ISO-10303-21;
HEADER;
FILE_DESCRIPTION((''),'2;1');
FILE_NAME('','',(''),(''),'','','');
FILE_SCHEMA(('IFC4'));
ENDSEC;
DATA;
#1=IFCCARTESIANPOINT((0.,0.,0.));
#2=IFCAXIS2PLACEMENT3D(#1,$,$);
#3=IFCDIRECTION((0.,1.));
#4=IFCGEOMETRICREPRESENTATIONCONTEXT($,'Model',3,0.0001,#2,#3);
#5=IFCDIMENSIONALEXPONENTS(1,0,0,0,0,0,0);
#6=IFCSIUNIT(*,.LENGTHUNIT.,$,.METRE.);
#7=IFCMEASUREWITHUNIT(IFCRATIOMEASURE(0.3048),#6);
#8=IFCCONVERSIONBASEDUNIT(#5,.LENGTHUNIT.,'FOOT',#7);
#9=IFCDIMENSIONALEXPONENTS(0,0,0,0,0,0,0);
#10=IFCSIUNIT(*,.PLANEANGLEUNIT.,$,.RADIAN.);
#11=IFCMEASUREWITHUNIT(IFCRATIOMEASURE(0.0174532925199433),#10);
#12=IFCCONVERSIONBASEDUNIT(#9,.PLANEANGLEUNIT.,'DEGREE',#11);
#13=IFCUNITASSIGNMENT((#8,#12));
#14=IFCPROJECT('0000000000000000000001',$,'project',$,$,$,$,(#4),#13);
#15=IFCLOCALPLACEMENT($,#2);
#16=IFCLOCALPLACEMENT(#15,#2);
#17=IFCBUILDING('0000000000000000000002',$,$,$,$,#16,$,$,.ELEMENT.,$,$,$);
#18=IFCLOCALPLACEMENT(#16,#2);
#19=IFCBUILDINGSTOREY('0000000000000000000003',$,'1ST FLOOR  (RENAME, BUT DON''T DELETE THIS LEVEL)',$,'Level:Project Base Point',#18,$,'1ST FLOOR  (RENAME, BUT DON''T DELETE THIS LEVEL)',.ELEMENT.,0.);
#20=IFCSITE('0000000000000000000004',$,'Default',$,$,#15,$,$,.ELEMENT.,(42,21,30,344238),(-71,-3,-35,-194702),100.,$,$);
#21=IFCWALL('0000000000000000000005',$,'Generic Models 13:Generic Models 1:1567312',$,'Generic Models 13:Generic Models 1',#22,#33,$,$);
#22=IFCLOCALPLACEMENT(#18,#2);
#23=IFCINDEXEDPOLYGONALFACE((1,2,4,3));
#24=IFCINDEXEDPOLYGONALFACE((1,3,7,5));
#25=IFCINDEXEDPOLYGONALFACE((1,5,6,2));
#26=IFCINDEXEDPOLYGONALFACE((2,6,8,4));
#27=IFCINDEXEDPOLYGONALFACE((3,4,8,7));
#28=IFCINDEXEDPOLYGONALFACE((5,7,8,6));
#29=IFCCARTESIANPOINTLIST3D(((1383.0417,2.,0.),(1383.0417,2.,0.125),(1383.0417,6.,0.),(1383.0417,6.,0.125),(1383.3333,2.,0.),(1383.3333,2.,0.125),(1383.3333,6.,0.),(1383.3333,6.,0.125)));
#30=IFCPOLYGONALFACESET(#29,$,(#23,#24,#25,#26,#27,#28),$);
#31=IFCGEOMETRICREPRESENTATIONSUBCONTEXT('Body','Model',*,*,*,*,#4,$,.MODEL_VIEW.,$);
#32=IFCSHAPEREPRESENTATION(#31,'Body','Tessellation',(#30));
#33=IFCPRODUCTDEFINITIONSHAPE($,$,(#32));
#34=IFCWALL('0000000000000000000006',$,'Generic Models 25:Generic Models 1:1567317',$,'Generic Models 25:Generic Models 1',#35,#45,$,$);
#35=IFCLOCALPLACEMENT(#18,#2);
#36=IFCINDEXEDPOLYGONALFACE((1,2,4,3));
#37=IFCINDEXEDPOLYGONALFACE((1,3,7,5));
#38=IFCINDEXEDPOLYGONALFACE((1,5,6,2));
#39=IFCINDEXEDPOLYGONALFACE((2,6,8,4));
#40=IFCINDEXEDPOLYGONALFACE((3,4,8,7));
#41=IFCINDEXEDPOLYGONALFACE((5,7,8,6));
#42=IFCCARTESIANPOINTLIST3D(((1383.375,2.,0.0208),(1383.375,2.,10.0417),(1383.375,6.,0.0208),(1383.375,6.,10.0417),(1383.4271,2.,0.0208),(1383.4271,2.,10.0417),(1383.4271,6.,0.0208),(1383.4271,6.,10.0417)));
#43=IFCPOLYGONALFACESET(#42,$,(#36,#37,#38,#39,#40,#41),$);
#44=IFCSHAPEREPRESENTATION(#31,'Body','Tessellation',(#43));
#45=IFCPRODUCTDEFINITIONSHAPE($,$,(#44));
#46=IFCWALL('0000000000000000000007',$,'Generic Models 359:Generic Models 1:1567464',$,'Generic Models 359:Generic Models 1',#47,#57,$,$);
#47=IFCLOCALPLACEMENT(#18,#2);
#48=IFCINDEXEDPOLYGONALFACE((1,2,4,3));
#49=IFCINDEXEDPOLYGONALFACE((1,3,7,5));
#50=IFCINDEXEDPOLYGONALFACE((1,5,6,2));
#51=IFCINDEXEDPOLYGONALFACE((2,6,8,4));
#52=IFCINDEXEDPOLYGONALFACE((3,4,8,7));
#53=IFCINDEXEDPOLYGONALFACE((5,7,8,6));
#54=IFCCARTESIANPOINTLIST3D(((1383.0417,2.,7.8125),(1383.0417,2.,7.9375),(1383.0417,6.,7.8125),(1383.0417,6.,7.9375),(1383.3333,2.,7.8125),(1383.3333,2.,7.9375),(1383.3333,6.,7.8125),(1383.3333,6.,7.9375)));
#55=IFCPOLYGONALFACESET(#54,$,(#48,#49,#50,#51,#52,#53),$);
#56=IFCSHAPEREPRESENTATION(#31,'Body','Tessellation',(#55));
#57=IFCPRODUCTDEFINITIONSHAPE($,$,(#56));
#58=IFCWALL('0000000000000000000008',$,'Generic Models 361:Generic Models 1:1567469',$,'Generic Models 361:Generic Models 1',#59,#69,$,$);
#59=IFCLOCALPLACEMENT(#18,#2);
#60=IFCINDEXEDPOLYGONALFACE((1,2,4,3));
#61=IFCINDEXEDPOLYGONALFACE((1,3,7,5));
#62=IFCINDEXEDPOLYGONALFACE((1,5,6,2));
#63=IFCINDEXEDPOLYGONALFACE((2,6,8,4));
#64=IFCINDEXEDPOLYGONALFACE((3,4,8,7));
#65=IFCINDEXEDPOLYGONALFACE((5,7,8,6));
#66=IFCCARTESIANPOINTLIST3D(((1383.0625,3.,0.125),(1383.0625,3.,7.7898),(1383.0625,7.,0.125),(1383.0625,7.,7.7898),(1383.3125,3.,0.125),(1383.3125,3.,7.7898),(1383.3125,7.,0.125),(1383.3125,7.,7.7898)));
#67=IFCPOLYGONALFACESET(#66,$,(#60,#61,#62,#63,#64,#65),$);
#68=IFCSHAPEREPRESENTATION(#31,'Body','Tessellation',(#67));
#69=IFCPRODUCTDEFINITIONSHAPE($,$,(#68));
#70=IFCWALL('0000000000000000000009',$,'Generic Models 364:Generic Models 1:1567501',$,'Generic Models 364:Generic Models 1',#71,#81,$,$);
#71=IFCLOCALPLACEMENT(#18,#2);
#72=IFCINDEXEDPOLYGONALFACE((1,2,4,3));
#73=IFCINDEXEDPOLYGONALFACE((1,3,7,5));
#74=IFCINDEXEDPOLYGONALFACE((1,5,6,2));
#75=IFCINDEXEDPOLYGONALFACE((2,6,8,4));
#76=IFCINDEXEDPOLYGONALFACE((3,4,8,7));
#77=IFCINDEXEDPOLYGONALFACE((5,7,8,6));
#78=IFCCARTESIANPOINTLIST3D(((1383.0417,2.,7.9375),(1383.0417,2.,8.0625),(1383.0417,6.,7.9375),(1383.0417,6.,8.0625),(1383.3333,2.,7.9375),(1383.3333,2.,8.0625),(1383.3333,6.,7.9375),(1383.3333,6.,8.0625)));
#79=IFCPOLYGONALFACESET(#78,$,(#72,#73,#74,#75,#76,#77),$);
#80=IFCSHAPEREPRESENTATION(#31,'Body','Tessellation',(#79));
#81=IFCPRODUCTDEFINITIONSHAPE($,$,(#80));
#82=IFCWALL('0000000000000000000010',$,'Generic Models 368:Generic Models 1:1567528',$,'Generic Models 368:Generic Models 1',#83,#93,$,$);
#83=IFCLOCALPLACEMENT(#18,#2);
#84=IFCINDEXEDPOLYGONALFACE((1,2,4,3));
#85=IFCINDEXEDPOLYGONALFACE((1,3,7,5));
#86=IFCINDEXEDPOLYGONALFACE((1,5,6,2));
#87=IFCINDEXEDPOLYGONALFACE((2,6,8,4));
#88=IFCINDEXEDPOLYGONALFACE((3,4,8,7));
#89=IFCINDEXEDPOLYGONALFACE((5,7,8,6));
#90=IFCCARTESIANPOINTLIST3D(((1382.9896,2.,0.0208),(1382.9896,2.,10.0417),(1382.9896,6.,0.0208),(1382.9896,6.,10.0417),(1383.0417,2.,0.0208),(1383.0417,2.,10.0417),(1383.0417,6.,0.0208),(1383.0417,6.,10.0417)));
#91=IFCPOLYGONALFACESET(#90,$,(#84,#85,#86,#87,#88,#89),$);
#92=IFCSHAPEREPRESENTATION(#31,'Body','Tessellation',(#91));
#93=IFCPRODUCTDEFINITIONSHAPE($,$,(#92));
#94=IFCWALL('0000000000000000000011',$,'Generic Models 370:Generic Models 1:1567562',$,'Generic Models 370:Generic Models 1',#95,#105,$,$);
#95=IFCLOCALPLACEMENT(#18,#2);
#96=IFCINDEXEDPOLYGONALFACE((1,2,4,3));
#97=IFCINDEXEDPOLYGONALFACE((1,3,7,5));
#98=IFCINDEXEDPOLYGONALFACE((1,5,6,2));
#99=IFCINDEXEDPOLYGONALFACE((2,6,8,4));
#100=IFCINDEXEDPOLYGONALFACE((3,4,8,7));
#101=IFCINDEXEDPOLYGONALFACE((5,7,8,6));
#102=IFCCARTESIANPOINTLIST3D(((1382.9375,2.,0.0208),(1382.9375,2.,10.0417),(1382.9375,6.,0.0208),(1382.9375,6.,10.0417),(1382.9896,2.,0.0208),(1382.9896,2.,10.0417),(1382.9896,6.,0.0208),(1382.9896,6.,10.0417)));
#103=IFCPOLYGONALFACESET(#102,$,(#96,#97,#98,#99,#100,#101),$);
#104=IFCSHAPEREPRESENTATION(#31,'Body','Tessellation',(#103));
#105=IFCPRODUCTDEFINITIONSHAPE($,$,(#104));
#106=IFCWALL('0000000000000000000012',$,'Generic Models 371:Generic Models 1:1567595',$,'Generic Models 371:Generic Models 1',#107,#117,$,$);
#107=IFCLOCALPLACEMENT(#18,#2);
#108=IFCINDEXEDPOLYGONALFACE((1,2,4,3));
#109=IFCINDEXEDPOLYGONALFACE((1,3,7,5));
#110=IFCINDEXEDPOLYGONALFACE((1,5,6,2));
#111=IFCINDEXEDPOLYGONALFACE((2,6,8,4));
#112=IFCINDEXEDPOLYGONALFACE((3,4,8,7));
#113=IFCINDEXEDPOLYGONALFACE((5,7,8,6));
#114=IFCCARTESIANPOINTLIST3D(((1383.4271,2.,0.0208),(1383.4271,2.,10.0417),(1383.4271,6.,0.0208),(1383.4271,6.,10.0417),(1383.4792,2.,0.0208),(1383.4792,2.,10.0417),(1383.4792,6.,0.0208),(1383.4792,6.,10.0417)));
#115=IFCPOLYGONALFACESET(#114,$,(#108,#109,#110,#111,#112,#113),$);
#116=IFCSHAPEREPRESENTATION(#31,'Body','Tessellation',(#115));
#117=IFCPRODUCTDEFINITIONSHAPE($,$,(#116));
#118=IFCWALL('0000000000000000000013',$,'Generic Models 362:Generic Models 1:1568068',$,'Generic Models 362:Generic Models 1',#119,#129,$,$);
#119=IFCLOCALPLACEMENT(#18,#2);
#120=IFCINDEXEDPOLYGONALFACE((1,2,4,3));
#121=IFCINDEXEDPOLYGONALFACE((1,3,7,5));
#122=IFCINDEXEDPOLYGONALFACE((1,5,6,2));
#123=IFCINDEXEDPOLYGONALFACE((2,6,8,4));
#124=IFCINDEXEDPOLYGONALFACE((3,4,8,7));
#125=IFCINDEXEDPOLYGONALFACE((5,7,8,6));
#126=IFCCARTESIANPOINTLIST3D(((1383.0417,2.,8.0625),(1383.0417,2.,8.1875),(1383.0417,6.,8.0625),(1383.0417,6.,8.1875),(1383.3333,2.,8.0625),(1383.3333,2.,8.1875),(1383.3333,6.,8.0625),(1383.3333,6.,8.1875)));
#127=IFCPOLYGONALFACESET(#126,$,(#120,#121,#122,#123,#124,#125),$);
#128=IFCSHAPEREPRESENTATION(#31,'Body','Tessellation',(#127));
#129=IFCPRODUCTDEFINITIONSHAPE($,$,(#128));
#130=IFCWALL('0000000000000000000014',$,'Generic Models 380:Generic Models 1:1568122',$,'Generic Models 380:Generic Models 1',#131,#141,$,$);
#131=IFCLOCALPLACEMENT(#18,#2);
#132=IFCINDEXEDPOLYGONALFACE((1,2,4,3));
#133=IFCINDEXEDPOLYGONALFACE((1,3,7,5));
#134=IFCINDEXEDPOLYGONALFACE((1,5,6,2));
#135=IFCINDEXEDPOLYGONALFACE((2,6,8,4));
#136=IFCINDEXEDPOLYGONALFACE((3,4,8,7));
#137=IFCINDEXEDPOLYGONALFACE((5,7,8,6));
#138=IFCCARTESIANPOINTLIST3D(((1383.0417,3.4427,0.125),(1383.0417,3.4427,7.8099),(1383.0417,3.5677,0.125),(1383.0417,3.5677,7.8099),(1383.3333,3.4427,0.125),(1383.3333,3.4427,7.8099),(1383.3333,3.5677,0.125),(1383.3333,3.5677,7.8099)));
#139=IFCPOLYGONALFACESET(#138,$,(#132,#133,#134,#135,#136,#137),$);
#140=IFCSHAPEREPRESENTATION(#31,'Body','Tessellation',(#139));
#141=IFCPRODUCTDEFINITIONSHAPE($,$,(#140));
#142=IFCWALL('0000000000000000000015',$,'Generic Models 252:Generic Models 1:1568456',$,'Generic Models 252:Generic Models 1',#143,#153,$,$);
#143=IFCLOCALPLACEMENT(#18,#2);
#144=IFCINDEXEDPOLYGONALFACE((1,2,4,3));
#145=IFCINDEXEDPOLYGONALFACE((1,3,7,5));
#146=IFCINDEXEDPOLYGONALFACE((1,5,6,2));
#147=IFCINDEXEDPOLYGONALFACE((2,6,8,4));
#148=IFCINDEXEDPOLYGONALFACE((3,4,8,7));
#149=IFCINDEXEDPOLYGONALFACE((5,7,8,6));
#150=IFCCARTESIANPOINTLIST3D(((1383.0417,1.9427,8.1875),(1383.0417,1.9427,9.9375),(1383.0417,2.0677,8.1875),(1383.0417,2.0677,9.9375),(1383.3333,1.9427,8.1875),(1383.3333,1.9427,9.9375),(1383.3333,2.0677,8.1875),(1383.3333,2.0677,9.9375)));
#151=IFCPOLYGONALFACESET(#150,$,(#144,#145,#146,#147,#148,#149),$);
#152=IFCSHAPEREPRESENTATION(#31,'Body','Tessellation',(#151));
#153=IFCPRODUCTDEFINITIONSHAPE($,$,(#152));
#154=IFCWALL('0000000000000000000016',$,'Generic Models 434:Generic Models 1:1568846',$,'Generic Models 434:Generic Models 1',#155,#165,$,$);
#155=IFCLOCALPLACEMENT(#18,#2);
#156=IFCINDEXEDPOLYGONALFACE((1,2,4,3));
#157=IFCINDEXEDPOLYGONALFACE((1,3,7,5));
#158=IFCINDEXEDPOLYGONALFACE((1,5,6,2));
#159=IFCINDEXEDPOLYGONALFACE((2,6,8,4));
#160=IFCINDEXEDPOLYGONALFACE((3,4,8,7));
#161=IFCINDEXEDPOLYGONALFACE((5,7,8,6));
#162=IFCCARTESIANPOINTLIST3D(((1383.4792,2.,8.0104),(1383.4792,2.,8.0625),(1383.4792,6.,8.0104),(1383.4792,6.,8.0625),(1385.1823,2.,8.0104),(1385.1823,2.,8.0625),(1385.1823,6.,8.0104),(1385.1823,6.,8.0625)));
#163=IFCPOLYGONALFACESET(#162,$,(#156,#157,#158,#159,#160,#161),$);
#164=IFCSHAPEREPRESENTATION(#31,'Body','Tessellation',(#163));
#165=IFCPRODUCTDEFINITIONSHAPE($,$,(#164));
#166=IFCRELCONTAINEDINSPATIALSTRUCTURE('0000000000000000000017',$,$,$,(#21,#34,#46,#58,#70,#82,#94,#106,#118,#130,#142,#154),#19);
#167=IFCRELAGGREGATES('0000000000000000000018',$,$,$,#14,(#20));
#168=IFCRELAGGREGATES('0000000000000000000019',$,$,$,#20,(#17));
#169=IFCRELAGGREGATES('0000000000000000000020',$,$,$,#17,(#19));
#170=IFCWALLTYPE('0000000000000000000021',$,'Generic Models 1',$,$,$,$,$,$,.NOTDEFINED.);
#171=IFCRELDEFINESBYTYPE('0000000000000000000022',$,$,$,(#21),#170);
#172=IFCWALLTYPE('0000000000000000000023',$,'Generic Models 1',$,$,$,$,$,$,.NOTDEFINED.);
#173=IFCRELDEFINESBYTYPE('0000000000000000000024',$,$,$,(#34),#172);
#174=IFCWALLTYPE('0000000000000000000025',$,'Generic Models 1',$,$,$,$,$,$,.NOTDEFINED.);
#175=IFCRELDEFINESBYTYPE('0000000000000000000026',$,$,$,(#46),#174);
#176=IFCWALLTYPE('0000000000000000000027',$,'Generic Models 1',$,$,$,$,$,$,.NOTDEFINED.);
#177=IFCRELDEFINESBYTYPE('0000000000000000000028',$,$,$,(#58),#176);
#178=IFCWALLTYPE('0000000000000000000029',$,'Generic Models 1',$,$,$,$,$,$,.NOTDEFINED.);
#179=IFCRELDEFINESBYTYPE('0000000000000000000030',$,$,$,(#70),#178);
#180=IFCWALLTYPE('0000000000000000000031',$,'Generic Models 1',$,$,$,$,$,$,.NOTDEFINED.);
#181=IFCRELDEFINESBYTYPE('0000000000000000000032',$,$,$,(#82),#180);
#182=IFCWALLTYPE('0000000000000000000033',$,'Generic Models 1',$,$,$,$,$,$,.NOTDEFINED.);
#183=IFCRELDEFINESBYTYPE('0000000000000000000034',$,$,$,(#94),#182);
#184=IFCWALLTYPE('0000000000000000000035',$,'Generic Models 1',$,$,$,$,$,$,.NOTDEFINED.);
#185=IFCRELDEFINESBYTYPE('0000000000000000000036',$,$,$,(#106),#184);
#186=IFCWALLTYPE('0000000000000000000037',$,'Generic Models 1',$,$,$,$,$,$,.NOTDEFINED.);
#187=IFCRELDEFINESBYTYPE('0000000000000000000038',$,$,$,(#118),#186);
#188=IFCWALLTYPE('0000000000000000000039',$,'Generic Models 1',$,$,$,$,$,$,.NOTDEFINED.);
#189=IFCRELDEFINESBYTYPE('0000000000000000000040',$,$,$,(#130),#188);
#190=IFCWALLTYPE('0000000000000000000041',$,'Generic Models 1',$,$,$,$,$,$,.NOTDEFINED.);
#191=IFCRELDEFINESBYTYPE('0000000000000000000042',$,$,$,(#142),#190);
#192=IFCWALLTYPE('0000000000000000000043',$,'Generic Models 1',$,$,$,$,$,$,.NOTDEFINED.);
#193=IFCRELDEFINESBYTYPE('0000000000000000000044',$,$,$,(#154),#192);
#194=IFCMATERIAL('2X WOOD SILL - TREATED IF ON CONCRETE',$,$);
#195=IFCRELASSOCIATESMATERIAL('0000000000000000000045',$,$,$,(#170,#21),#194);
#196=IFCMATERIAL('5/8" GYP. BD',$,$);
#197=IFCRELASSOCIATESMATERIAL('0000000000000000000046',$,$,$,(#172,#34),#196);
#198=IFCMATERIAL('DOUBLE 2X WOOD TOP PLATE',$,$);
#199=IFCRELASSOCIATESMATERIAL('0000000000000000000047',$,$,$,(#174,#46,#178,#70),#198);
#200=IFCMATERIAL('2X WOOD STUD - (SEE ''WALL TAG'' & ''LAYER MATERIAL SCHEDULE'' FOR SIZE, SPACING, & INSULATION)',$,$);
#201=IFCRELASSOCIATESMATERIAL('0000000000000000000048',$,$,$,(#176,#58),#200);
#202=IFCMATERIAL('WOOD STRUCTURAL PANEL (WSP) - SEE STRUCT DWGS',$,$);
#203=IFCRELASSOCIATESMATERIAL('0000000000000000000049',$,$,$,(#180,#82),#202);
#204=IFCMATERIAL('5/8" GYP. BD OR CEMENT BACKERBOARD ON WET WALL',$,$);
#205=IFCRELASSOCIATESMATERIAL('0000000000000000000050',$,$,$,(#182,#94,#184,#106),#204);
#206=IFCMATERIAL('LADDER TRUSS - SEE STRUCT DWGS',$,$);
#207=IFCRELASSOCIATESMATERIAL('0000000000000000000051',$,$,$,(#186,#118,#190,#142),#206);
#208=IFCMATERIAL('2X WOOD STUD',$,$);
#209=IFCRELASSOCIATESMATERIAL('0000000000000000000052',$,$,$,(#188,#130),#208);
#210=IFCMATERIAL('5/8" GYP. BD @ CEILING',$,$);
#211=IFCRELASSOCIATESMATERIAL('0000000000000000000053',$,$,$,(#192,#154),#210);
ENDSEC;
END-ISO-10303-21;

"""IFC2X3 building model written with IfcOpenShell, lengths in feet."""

from ifc_helpers import new_model, entity, si_unit, converted_unit, direction, frame, frame_2d, origin, origin_2d_with_axis, place, context, subcontext, project, spatial, rectangle, extrude, material, type_object, element, save


model = new_model("IFC2X3")

# Units and contexts
model_context = context("Model", 3, precision=0.0001, world=origin(), true_north=direction((0.0, 1.0)))
body_context = subcontext(model_context, "Body", "Model", "MODEL_VIEW")
ifc_project = project(units=[converted_unit("LENGTHUNIT", "FOOT", entity("IfcRatioMeasure", 0.3048), si_unit("LENGTHUNIT", "METRE"), dimensions=[1, 0, 0, 0, 0, 0, 0]), converted_unit("PLANEANGLEUNIT", "DEGREE", entity("IfcRatioMeasure", 0.0174532925199433), si_unit("PLANEANGLEUNIT", "RADIAN"), dimensions=[0, 0, 0, 0, 0, 0, 0])], contexts=[model_context])

# Site, building, storey
site_placement = place(None, origin())
site = spatial("IfcSite", under=ifc_project, at=site_placement, Name="Default", CompositionType="ELEMENT", RefLatitude=(42, 21, 30, 344238), RefLongitude=(-71, -3, -35, -194702), RefElevation=100.0)
building_placement = place(site_placement, origin())
building = spatial("IfcBuilding", under=site, at=building_placement, CompositionType="ELEMENT")
storey_placement = place(building_placement, origin())
storey = spatial("IfcBuildingStorey", under=building, at=storey_placement, Name="1ST FLOOR  (RENAME, BUT DON'T DELETE THIS LEVEL)", ObjectType="Level:Project Base Point", LongName="1ST FLOOR  (RENAME, BUT DON'T DELETE THIS LEVEL)", CompositionType="ELEMENT", Elevation=0.0)

# Walls
ifc_material_1 = material(Name="2X WOOD SILL - TREATED IF ON CONCRETE")
wall_type_1 = type_object("IfcWallType", Name="Generic Models 1", PredefinedType="NOTDEFINED", material=ifc_material_1)
wall_1_placement = place(storey_placement, frame((1383.0417, 2.0, 0.0), z_axis=(0.0, 0.0, 1.0), x_axis=(0.0, 1.0, 0.0)))
element("IfcWall", 1, at=wall_1_placement, inside=storey, type_object=wall_type_1, material=ifc_material_1, Name="Generic Models 13:Generic Models 1:1567312", ObjectType="Generic Models 13:Generic Models 1", context=body_context, shape_type="SweptSolid", body=[
    extrude(rectangle(XDim=4.0, YDim=0.2917, at=frame_2d((0.0, 0.0), x_axis=(1.0, 0.0))), frame((2.0, -0.1458, 0.0)), (0.0, 0.0, 1.0), 0.125),
])
ifc_material_2 = material(Name="5/8\" GYP. BD")
wall_type_2 = type_object("IfcWallType", Name="Generic Models 1", PredefinedType="NOTDEFINED", material=ifc_material_2)
wall_2_placement = place(storey_placement, frame((1383.375, 2.0, 0.0208), z_axis=(0.0, 0.0, 1.0), x_axis=(0.0, 1.0, 0.0)))
element("IfcWall", 2, at=wall_2_placement, inside=storey, type_object=wall_type_2, material=ifc_material_2, Name="Generic Models 25:Generic Models 1:1567317", ObjectType="Generic Models 25:Generic Models 1", context=body_context, shape_type="SweptSolid", body=[
    extrude(rectangle(XDim=4.0, YDim=0.0521, at=origin_2d_with_axis()), frame((2.0, -0.026, 0.0)), (0.0, 0.0, 1.0), 10.0208),
])
ifc_material_3 = material(Name="DOUBLE 2X WOOD TOP PLATE")
wall_type_3 = type_object("IfcWallType", Name="Generic Models 1", PredefinedType="NOTDEFINED", material=ifc_material_3)
wall_3_placement = place(storey_placement, frame((1383.0417, 2.0, 7.8125), z_axis=(0.0, 0.0, 1.0), x_axis=(0.0, 1.0, 0.0)))
element("IfcWall", 3, at=wall_3_placement, inside=storey, type_object=wall_type_3, material=ifc_material_3, Name="Generic Models 359:Generic Models 1:1567464", ObjectType="Generic Models 359:Generic Models 1", context=body_context, shape_type="SweptSolid", body=[
    extrude(rectangle(XDim=4.0, YDim=0.2917, at=frame_2d((0.0, 0.0), x_axis=(1.0, 0.0))), frame((2.0, -0.1458, 0.0)), (0.0, 0.0, 1.0), 0.125),
])
ifc_material_4 = material(Name="2X WOOD STUD - (SEE 'WALL TAG' & 'LAYER MATERIAL SCHEDULE' FOR SIZE, SPACING, & INSULATION)")
wall_type_4 = type_object("IfcWallType", Name="Generic Models 1", PredefinedType="NOTDEFINED", material=ifc_material_4)
wall_4_placement = place(storey_placement, frame((1383.0625, 3.0, 0.125), z_axis=(0.0, 0.0, 1.0), x_axis=(0.0, 1.0, 0.0)))
element("IfcWall", 4, at=wall_4_placement, inside=storey, type_object=wall_type_4, material=ifc_material_4, Name="Generic Models 361:Generic Models 1:1567469", ObjectType="Generic Models 361:Generic Models 1", context=body_context, shape_type="SweptSolid", body=[
    extrude(rectangle(XDim=4.0, YDim=0.25, at=frame_2d((0.0, 0.0), x_axis=(1.0, 0.0))), frame((2.0, -0.125, 0.0)), (0.0, 0.0, 1.0), 7.6648),
])
wall_type_5 = type_object("IfcWallType", Name="Generic Models 1", PredefinedType="NOTDEFINED", material=ifc_material_3)
wall_5_placement = place(storey_placement, frame((1383.0417, 2.0, 7.9375), z_axis=(0.0, 0.0, 1.0), x_axis=(0.0, 1.0, 0.0)))
element("IfcWall", 5, at=wall_5_placement, inside=storey, type_object=wall_type_5, material=ifc_material_3, Name="Generic Models 364:Generic Models 1:1567501", ObjectType="Generic Models 364:Generic Models 1", context=body_context, shape_type="SweptSolid", body=[
    extrude(rectangle(XDim=4.0, YDim=0.2917, at=frame_2d((0.0, 0.0), x_axis=(1.0, 0.0))), frame((2.0, -0.1458, 0.0)), (0.0, 0.0, 1.0), 0.125),
])
ifc_material_5 = material(Name="WOOD STRUCTURAL PANEL (WSP) - SEE STRUCT DWGS")
wall_type_6 = type_object("IfcWallType", Name="Generic Models 1", PredefinedType="NOTDEFINED", material=ifc_material_5)
wall_6_placement = place(storey_placement, frame((1382.9896, 2.0, 0.0208), z_axis=(0.0, 0.0, 1.0), x_axis=(0.0, 1.0, 0.0)))
element("IfcWall", 6, at=wall_6_placement, inside=storey, type_object=wall_type_6, material=ifc_material_5, Name="Generic Models 368:Generic Models 1:1567528", ObjectType="Generic Models 368:Generic Models 1", context=body_context, shape_type="SweptSolid", body=[
    extrude(rectangle(XDim=4.0, YDim=0.0521, at=frame_2d((0.0, 0.0), x_axis=(1.0, 0.0))), frame((2.0, -0.026, 0.0)), (0.0, 0.0, 1.0), 10.0208),
])
ifc_material_6 = material(Name="5/8\" GYP. BD OR CEMENT BACKERBOARD ON WET WALL")
wall_type_7 = type_object("IfcWallType", Name="Generic Models 1", PredefinedType="NOTDEFINED", material=ifc_material_6)
wall_7_placement = place(storey_placement, frame((1382.9375, 2.0, 0.0208), z_axis=(0.0, 0.0, 1.0), x_axis=(0.0, 1.0, 0.0)))
element("IfcWall", 7, at=wall_7_placement, inside=storey, type_object=wall_type_7, material=ifc_material_6, Name="Generic Models 370:Generic Models 1:1567562", ObjectType="Generic Models 370:Generic Models 1", context=body_context, shape_type="SweptSolid", body=[
    extrude(rectangle(XDim=4.0, YDim=0.0521, at=frame_2d((0.0, 0.0), x_axis=(1.0, 0.0))), frame((2.0, -0.026, 0.0)), (0.0, 0.0, 1.0), 10.0208),
])
wall_type_8 = type_object("IfcWallType", Name="Generic Models 1", PredefinedType="NOTDEFINED", material=ifc_material_6)
wall_8_placement = place(storey_placement, frame((1383.4271, 2.0, 0.0208), z_axis=(0.0, 0.0, 1.0), x_axis=(0.0, 1.0, 0.0)))
element("IfcWall", 8, at=wall_8_placement, inside=storey, type_object=wall_type_8, material=ifc_material_6, Name="Generic Models 371:Generic Models 1:1567595", ObjectType="Generic Models 371:Generic Models 1", context=body_context, shape_type="SweptSolid", body=[
    extrude(rectangle(XDim=4.0, YDim=0.0521, at=frame_2d((0.0, 0.0), x_axis=(1.0, 0.0))), frame((2.0, -0.026, 0.0)), (0.0, 0.0, 1.0), 10.0208),
])
ifc_material_7 = material(Name="LADDER TRUSS - SEE STRUCT DWGS")
wall_type_9 = type_object("IfcWallType", Name="Generic Models 1", PredefinedType="NOTDEFINED", material=ifc_material_7)
wall_9_placement = place(storey_placement, frame((1383.0417, 2.0, 8.0625), z_axis=(0.0, 0.0, 1.0), x_axis=(0.0, 1.0, 0.0)))
element("IfcWall", 9, at=wall_9_placement, inside=storey, type_object=wall_type_9, material=ifc_material_7, Name="Generic Models 362:Generic Models 1:1568068", ObjectType="Generic Models 362:Generic Models 1", context=body_context, shape_type="SweptSolid", body=[
    extrude(rectangle(XDim=4.0, YDim=0.2917, at=origin_2d_with_axis()), frame((2.0, -0.1458, 0.0)), (0.0, 0.0, 1.0), 0.125),
])
ifc_material_8 = material(Name="2X WOOD STUD")
wall_type_10 = type_object("IfcWallType", Name="Generic Models 1", PredefinedType="NOTDEFINED", material=ifc_material_8)
wall_10_placement = place(storey_placement, frame((1383.0417, 3.4427, 0.125)))
element("IfcWall", 10, at=wall_10_placement, inside=storey, type_object=wall_type_10, material=ifc_material_8, Name="Generic Models 380:Generic Models 1:1568122", ObjectType="Generic Models 380:Generic Models 1", context=body_context, shape_type="SweptSolid", body=[
    extrude(rectangle(XDim=0.125, YDim=0.2917, at=frame_2d((0.0, 0.0), x_axis=(1.0, 0.0))), frame((0.1458, 0.0625, 0.0), z_axis=(0.0, 0.0, 1.0), x_axis=(0.0, 1.0, 0.0)), (0.0, 0.0, 1.0), 7.6849),
])
wall_type_11 = type_object("IfcWallType", Name="Generic Models 1", PredefinedType="NOTDEFINED", material=ifc_material_7)
wall_11_placement = place(storey_placement, frame((1383.0417, 1.9427, 8.1875)))
element("IfcWall", 11, at=wall_11_placement, inside=storey, type_object=wall_type_11, material=ifc_material_7, Name="Generic Models 252:Generic Models 1:1568456", ObjectType="Generic Models 252:Generic Models 1", context=body_context, shape_type="SweptSolid", body=[
    extrude(rectangle(XDim=0.125, YDim=0.2917, at=frame_2d((0.0, 0.0), x_axis=(1.0, 0.0))), frame((0.1458, 0.0625, 0.0), z_axis=(0.0, 0.0, 1.0), x_axis=(0.0, 1.0, 0.0)), (0.0, 0.0, 1.0), 1.75),
])
ifc_material_9 = material(Name="5/8\" GYP. BD @ CEILING")
wall_type_12 = type_object("IfcWallType", Name="Generic Models 1", PredefinedType="NOTDEFINED", material=ifc_material_9)
wall_12_placement = place(storey_placement, frame((1383.4792, 2.0, 8.0104), z_axis=(0.0, 0.0, 1.0), x_axis=(0.0, 1.0, 0.0)))
element("IfcWall", 12, at=wall_12_placement, inside=storey, type_object=wall_type_12, material=ifc_material_9, Name="Generic Models 434:Generic Models 1:1568846", ObjectType="Generic Models 434:Generic Models 1", context=body_context, shape_type="SweptSolid", body=[
    extrude(rectangle(XDim=4.0, YDim=1.7031, at=frame_2d((0.0, 0.0), x_axis=(1.0, 0.0))), frame((2.0, -0.8516, 0.0)), (0.0, 0.0, 1.0), 0.0521),
])

save(model, "model.ifc")
